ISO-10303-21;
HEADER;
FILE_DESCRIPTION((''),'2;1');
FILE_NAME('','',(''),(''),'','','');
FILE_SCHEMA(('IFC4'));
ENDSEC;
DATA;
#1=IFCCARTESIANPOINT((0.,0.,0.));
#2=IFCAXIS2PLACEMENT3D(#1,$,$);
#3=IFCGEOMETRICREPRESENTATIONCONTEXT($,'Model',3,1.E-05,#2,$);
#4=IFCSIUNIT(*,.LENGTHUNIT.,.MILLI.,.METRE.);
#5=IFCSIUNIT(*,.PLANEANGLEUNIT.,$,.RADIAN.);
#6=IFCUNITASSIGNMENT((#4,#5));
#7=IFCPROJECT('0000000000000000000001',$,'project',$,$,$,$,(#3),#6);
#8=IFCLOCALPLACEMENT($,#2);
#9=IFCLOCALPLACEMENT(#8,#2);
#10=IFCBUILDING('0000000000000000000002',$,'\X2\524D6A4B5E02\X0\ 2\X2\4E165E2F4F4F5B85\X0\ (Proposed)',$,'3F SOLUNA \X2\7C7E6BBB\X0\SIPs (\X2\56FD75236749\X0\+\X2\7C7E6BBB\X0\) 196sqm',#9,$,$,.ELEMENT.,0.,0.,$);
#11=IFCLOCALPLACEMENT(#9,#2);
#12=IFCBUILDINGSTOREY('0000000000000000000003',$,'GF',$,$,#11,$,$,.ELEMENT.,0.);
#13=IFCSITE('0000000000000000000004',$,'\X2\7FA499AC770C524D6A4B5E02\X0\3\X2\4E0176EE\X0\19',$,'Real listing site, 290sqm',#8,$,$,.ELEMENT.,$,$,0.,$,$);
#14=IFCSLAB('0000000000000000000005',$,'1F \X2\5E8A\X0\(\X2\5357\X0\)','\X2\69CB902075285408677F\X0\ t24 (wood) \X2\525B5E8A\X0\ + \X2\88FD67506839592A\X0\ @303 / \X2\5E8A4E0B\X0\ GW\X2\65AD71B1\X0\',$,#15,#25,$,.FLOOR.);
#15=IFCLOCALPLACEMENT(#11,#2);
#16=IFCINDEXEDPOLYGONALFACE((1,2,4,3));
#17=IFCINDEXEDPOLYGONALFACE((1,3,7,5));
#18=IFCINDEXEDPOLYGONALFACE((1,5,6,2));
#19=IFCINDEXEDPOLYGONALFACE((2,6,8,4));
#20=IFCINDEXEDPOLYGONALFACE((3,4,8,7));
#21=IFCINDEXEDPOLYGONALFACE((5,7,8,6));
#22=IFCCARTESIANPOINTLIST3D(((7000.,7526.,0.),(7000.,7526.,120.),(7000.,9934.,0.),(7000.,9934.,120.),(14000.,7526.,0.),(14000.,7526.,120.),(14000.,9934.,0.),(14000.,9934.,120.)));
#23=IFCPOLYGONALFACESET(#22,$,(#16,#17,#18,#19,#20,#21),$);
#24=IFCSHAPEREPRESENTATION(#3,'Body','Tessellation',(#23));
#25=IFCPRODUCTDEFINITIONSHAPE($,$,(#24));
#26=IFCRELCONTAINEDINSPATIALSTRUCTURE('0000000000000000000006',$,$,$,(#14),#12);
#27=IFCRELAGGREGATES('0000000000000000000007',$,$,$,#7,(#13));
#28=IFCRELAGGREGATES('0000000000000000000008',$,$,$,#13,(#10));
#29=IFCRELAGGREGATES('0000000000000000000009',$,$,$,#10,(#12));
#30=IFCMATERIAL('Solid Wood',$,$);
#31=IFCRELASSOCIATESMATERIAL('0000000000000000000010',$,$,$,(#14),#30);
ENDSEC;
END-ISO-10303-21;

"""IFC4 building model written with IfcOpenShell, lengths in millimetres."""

from ifc_helpers import new_model, si_unit, frame, frame_2d, origin, place, context, project, spatial, rectangle, extrude, material, element, save


model = new_model("IFC4")

# Units and contexts
model_context = context("Model", 3, precision=1e-05, world=origin())
ifc_project = project(units=[si_unit("LENGTHUNIT", "METRE", prefix="MILLI"), si_unit("PLANEANGLEUNIT", "RADIAN")], contexts=[model_context])

# Site, building, storey
site_placement = place(None, origin())
site = spatial("IfcSite", under=ifc_project, at=site_placement, Name="群馬県前橋市3丁目19", ObjectType="Real listing site, 290sqm", CompositionType="ELEMENT", RefElevation=0.0)
building_placement = place(site_placement, origin())
building = spatial("IfcBuilding", under=site, at=building_placement, Name="前橋市 2世帯住宅 (Proposed)", ObjectType="3F SOLUNA 籾殻SIPs (国産杉+籾殻) 196sqm", CompositionType="ELEMENT", ElevationOfRefHeight=0.0, ElevationOfTerrain=0.0)
storey_placement = place(building_placement, origin())
storey = spatial("IfcBuildingStorey", under=building, at=storey_placement, Name="GF", CompositionType="ELEMENT", Elevation=0.0)

# Slab
ifc_material_1 = material(Name="Solid Wood")
slab_1_placement = place(storey_placement, frame((3500.0, 3763.0, 0.0)))
element("IfcSlab", 1, at=slab_1_placement, inside=storey, material=ifc_material_1, Name="1F 床(南)", Description="構造用合板 t24 (wood) 剛床 + 製材根太 @303 / 床下 GW断熱", PredefinedType="FLOOR", context=model_context, shape_type="SweptSolid", body=[
    extrude(rectangle(XDim=7000.0, YDim=2408.0, at=frame_2d((3500.0, 1204.0))), frame((3500.0, 3763.0, 0.0)), (0.0, 0.0, 1.0), 120.0),
])

save(model, "model.ifc")
